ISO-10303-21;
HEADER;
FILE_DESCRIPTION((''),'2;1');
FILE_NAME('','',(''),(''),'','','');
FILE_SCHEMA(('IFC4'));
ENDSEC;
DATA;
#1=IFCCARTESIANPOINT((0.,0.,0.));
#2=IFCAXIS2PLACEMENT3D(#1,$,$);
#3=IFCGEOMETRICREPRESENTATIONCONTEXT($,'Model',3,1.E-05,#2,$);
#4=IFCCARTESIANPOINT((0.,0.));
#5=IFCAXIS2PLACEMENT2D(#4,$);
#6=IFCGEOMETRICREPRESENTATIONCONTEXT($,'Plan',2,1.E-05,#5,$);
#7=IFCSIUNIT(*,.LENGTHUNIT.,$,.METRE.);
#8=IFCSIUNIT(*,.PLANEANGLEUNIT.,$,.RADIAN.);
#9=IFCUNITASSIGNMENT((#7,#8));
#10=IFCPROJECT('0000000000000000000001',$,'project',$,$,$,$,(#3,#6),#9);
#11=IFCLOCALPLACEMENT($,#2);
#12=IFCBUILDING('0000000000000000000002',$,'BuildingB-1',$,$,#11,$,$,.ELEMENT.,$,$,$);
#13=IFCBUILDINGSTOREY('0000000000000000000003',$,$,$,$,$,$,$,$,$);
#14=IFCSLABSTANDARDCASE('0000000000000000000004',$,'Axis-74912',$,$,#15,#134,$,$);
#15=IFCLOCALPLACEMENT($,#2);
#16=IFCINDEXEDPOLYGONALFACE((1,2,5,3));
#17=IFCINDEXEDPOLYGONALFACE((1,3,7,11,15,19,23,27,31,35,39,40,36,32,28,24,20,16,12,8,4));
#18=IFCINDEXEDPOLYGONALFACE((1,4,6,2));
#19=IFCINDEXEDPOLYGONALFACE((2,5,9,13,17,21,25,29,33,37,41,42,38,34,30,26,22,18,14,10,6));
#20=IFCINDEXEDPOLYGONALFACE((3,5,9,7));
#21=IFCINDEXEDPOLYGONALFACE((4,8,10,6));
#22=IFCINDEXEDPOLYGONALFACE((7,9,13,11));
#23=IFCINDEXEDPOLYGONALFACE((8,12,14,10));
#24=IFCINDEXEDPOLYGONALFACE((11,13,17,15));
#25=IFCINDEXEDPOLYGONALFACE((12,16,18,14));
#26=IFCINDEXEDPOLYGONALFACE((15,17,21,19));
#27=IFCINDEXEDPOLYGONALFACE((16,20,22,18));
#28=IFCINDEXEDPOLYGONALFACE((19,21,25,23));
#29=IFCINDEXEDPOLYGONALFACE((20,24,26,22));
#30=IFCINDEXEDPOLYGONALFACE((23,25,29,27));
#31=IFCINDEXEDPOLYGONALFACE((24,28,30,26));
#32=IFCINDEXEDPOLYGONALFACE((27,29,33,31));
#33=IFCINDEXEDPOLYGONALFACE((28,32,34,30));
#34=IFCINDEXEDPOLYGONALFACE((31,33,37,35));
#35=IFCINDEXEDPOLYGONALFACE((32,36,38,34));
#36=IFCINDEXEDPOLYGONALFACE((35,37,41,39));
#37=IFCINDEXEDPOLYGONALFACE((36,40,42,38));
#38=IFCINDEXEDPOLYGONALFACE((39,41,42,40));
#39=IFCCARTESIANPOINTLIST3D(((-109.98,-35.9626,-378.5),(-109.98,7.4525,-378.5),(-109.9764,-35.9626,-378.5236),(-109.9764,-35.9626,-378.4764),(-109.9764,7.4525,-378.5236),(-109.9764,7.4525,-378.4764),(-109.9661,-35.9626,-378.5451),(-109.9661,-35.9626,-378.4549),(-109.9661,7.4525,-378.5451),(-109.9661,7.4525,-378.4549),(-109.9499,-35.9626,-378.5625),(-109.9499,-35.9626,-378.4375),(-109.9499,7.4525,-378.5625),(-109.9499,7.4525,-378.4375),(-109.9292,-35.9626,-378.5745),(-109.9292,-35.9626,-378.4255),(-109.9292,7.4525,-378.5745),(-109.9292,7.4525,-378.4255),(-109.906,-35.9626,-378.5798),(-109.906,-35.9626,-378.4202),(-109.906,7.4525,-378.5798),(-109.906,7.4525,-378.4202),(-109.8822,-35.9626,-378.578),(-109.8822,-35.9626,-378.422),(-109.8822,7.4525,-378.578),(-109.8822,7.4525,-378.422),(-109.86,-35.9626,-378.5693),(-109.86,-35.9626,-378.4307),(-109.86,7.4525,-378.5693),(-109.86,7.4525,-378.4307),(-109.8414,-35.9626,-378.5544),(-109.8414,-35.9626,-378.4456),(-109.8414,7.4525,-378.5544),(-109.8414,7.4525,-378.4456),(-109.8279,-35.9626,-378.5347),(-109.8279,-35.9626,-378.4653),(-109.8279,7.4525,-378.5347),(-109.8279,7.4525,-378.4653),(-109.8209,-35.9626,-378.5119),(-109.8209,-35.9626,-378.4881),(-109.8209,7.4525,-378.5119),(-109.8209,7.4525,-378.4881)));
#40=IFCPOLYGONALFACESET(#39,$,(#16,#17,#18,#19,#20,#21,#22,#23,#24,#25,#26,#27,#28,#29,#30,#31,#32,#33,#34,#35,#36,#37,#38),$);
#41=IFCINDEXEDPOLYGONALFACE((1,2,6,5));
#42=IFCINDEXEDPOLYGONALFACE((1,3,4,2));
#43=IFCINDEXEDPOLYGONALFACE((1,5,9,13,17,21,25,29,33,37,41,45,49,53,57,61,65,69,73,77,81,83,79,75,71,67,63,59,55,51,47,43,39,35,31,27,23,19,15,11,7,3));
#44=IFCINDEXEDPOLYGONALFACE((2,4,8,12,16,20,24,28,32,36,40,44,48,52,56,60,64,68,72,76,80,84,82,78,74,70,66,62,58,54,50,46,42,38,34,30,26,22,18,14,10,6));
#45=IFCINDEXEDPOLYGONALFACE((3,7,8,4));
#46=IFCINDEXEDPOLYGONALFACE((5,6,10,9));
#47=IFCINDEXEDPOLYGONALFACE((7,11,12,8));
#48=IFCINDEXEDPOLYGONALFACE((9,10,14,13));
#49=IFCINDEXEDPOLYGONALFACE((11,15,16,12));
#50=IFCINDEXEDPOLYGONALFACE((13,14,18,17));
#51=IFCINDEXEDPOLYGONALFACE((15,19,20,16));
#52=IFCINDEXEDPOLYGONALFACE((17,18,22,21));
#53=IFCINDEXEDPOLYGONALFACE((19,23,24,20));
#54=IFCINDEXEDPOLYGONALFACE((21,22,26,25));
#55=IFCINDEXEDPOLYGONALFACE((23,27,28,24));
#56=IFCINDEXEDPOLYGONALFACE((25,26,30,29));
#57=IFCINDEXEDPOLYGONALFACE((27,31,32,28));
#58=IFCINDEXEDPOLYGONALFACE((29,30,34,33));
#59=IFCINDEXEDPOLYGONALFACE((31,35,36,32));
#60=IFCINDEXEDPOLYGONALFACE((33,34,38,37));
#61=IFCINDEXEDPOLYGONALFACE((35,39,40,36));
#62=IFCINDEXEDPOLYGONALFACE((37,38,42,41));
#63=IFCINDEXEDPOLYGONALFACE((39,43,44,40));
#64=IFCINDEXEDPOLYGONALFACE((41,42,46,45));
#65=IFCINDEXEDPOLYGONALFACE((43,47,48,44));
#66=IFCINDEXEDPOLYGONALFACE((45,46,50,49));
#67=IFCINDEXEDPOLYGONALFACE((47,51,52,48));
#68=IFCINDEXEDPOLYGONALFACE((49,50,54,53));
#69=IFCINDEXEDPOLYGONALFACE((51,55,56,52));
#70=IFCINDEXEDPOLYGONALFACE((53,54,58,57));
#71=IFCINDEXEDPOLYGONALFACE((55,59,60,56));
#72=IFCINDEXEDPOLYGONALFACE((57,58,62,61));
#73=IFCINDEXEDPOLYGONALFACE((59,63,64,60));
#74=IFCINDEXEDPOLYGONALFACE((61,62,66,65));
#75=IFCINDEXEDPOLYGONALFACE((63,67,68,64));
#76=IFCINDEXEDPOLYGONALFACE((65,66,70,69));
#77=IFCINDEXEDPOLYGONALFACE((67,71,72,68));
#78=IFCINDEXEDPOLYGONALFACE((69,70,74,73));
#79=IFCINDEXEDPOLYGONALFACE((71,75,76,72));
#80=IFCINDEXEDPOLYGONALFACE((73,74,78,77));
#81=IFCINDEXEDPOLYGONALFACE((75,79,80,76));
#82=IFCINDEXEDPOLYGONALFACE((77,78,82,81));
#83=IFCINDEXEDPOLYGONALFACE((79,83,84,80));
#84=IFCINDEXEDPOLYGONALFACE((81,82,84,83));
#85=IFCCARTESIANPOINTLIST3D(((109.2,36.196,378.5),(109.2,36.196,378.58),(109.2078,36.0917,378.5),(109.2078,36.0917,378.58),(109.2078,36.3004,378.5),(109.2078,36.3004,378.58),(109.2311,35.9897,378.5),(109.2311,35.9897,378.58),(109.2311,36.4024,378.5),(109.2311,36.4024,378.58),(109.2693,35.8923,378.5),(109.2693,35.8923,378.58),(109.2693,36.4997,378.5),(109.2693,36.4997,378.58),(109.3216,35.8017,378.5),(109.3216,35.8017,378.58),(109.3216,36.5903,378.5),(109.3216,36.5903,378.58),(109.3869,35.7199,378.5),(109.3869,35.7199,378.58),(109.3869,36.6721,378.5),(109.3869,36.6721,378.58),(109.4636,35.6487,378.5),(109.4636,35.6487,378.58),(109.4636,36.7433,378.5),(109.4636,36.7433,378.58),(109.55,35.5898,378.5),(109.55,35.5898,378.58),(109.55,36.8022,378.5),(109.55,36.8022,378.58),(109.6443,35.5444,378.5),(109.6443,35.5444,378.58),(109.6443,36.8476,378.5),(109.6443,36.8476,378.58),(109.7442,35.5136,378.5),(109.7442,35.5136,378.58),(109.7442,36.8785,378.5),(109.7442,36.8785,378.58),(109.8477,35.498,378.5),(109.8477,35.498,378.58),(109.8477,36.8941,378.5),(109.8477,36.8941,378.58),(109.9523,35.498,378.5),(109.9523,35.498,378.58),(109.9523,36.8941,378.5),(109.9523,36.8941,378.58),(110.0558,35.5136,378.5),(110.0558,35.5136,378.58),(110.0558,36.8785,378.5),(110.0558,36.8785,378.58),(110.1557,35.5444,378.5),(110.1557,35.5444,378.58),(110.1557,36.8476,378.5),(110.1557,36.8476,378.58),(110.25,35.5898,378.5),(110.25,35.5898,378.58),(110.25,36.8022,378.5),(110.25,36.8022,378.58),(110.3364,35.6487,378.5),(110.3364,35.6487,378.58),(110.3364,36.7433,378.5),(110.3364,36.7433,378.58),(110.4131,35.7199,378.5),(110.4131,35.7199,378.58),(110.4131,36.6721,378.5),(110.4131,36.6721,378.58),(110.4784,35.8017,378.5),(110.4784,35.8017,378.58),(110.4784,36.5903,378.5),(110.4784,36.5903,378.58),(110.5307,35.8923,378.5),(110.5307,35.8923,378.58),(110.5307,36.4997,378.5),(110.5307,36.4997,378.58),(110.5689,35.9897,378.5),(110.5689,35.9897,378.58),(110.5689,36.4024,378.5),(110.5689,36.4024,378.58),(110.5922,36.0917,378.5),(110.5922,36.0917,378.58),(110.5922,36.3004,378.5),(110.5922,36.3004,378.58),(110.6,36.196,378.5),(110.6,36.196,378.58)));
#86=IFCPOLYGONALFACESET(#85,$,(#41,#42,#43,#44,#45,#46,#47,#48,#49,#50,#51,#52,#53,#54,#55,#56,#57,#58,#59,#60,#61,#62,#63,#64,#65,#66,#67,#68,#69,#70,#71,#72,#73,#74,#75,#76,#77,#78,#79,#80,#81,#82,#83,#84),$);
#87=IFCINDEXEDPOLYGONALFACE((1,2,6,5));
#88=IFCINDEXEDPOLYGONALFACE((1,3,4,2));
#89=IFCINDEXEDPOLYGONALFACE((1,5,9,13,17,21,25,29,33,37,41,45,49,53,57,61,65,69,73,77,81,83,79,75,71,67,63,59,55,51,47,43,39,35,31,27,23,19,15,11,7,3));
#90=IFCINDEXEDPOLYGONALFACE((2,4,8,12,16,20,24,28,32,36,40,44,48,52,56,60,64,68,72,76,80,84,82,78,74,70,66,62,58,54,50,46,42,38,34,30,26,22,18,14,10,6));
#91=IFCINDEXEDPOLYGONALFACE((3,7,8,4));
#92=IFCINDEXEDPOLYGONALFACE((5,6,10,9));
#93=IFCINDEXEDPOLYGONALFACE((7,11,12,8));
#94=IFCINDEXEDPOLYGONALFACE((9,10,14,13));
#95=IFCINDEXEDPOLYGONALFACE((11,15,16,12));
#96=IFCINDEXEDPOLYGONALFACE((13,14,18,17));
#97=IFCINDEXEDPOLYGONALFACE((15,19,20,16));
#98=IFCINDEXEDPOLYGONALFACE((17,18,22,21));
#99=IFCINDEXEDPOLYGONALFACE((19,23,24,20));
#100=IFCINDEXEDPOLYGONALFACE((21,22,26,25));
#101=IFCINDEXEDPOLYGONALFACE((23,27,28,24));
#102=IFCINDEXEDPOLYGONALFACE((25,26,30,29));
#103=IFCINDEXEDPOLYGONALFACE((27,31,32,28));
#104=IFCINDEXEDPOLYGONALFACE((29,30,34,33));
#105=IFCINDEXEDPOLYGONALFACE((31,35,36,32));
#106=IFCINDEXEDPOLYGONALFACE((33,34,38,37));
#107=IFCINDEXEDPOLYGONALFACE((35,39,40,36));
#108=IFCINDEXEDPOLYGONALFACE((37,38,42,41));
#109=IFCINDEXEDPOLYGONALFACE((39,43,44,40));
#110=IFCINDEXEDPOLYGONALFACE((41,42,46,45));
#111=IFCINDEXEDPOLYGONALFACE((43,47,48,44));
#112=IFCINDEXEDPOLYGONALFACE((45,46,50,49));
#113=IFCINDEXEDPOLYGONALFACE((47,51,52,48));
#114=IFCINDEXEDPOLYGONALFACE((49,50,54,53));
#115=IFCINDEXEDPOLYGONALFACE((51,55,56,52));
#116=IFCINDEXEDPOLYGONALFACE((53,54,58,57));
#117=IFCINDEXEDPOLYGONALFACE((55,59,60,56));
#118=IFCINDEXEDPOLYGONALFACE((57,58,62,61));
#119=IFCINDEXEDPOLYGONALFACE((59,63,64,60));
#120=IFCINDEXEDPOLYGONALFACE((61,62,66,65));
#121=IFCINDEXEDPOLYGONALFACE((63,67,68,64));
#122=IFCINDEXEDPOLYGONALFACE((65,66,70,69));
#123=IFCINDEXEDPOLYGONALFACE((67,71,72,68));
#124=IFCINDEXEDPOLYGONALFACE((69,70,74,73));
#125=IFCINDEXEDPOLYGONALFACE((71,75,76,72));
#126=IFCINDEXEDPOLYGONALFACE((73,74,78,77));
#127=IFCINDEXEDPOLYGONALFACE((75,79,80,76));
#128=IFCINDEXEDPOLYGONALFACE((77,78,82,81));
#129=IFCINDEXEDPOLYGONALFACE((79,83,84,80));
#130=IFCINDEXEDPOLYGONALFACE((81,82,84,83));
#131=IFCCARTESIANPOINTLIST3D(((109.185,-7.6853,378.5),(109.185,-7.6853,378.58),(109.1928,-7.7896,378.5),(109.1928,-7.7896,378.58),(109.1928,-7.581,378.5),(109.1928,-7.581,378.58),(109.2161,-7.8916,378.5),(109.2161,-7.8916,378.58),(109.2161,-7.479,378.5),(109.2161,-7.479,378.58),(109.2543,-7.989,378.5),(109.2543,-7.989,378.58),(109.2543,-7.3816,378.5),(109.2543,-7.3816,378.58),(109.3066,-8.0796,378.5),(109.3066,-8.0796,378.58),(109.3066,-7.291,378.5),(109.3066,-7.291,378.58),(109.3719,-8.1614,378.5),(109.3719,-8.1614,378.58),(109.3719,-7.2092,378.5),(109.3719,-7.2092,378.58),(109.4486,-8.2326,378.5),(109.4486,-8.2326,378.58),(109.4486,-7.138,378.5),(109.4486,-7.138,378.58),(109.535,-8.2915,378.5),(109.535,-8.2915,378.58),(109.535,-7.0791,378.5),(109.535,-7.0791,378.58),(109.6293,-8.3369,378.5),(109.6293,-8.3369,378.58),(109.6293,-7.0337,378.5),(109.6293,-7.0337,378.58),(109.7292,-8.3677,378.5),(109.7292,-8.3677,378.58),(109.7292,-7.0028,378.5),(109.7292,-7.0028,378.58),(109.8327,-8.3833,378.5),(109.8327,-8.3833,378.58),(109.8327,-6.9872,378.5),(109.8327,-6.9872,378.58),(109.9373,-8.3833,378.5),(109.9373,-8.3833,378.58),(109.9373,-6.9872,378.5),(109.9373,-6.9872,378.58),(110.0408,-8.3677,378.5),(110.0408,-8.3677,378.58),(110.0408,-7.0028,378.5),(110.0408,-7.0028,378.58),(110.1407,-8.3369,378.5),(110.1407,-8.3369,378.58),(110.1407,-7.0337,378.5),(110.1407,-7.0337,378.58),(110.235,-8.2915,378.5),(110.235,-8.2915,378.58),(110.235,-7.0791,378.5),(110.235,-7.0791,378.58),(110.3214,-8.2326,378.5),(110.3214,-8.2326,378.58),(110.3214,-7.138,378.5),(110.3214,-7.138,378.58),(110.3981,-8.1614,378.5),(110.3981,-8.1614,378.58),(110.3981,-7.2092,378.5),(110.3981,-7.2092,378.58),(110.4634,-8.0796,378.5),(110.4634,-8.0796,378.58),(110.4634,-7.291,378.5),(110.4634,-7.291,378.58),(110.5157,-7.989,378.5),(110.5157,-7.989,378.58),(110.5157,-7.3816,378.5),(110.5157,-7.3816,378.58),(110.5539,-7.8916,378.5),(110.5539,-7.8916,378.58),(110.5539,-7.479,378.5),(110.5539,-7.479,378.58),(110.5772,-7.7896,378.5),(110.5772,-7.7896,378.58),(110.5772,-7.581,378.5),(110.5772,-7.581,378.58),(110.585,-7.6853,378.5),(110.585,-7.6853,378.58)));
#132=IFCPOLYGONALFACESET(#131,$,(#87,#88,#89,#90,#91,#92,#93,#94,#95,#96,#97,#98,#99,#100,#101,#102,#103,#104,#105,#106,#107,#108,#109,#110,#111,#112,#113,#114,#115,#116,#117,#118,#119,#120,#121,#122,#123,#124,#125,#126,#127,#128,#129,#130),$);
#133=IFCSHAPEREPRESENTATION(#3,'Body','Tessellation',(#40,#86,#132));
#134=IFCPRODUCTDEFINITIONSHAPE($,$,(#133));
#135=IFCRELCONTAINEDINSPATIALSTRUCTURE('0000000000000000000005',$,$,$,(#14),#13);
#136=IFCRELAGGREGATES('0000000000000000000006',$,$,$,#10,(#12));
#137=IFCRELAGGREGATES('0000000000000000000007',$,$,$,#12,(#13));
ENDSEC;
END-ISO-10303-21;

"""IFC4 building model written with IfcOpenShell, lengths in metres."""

from ifc_helpers import new_model, entity, si_unit, frame, origin, origin_2d, place, context, project, spatial, circle, extrude, element, save


model = new_model("IFC4")

# Units and contexts
model_context = context("Model", 3, precision=1e-05, world=origin())
plan_context = context("Plan", 2, precision=1e-05, world=origin_2d())
ifc_project = project(units=[si_unit("LENGTHUNIT", "METRE"), si_unit("PLANEANGLEUNIT", "RADIAN")], contexts=[model_context, plan_context])

# Building, storey
building_placement = place(None, origin())
building = spatial("IfcBuilding", under=ifc_project, at=building_placement, Name="BuildingB-1", CompositionType="ELEMENT")
storey = spatial("IfcBuildingStorey", under=building)

# Slab
element("IfcSlabStandardCase", 1, inside=storey, Name="Axis-74912", context=model_context, shape_type="AdvancedSweptSolid", body=[
    entity("IfcSurfaceCurveSweptAreaSolid", entity("IfcCircleProfileDef", "AREA", None, None, 0.08), None, entity("IfcPolyline", [entity("IfcCartesianPoint", [109.9, 35.9626, 378.5]), entity("IfcCartesianPoint", [109.9, -7.4525, 378.5])]), None, None, entity("IfcPlane", entity("IfcAxis2Placement3D", entity("IfcCartesianPoint", [109.9, 35.9626, 378.5]), entity("IfcDirection", [0.0, 0.0, 1.0]), entity("IfcDirection", [1.0, 0.0, 0.0])))),
    extrude(circle(Radius=0.7), frame((109.9, 36.196, 378.5)), (0.0, 0.0, 1.0), 0.08),
    extrude(circle(Radius=0.7), frame((109.885, -7.6853, 378.5)), (0.0, 0.0, 1.0), 0.08),
])

save(model, "model.ifc")
